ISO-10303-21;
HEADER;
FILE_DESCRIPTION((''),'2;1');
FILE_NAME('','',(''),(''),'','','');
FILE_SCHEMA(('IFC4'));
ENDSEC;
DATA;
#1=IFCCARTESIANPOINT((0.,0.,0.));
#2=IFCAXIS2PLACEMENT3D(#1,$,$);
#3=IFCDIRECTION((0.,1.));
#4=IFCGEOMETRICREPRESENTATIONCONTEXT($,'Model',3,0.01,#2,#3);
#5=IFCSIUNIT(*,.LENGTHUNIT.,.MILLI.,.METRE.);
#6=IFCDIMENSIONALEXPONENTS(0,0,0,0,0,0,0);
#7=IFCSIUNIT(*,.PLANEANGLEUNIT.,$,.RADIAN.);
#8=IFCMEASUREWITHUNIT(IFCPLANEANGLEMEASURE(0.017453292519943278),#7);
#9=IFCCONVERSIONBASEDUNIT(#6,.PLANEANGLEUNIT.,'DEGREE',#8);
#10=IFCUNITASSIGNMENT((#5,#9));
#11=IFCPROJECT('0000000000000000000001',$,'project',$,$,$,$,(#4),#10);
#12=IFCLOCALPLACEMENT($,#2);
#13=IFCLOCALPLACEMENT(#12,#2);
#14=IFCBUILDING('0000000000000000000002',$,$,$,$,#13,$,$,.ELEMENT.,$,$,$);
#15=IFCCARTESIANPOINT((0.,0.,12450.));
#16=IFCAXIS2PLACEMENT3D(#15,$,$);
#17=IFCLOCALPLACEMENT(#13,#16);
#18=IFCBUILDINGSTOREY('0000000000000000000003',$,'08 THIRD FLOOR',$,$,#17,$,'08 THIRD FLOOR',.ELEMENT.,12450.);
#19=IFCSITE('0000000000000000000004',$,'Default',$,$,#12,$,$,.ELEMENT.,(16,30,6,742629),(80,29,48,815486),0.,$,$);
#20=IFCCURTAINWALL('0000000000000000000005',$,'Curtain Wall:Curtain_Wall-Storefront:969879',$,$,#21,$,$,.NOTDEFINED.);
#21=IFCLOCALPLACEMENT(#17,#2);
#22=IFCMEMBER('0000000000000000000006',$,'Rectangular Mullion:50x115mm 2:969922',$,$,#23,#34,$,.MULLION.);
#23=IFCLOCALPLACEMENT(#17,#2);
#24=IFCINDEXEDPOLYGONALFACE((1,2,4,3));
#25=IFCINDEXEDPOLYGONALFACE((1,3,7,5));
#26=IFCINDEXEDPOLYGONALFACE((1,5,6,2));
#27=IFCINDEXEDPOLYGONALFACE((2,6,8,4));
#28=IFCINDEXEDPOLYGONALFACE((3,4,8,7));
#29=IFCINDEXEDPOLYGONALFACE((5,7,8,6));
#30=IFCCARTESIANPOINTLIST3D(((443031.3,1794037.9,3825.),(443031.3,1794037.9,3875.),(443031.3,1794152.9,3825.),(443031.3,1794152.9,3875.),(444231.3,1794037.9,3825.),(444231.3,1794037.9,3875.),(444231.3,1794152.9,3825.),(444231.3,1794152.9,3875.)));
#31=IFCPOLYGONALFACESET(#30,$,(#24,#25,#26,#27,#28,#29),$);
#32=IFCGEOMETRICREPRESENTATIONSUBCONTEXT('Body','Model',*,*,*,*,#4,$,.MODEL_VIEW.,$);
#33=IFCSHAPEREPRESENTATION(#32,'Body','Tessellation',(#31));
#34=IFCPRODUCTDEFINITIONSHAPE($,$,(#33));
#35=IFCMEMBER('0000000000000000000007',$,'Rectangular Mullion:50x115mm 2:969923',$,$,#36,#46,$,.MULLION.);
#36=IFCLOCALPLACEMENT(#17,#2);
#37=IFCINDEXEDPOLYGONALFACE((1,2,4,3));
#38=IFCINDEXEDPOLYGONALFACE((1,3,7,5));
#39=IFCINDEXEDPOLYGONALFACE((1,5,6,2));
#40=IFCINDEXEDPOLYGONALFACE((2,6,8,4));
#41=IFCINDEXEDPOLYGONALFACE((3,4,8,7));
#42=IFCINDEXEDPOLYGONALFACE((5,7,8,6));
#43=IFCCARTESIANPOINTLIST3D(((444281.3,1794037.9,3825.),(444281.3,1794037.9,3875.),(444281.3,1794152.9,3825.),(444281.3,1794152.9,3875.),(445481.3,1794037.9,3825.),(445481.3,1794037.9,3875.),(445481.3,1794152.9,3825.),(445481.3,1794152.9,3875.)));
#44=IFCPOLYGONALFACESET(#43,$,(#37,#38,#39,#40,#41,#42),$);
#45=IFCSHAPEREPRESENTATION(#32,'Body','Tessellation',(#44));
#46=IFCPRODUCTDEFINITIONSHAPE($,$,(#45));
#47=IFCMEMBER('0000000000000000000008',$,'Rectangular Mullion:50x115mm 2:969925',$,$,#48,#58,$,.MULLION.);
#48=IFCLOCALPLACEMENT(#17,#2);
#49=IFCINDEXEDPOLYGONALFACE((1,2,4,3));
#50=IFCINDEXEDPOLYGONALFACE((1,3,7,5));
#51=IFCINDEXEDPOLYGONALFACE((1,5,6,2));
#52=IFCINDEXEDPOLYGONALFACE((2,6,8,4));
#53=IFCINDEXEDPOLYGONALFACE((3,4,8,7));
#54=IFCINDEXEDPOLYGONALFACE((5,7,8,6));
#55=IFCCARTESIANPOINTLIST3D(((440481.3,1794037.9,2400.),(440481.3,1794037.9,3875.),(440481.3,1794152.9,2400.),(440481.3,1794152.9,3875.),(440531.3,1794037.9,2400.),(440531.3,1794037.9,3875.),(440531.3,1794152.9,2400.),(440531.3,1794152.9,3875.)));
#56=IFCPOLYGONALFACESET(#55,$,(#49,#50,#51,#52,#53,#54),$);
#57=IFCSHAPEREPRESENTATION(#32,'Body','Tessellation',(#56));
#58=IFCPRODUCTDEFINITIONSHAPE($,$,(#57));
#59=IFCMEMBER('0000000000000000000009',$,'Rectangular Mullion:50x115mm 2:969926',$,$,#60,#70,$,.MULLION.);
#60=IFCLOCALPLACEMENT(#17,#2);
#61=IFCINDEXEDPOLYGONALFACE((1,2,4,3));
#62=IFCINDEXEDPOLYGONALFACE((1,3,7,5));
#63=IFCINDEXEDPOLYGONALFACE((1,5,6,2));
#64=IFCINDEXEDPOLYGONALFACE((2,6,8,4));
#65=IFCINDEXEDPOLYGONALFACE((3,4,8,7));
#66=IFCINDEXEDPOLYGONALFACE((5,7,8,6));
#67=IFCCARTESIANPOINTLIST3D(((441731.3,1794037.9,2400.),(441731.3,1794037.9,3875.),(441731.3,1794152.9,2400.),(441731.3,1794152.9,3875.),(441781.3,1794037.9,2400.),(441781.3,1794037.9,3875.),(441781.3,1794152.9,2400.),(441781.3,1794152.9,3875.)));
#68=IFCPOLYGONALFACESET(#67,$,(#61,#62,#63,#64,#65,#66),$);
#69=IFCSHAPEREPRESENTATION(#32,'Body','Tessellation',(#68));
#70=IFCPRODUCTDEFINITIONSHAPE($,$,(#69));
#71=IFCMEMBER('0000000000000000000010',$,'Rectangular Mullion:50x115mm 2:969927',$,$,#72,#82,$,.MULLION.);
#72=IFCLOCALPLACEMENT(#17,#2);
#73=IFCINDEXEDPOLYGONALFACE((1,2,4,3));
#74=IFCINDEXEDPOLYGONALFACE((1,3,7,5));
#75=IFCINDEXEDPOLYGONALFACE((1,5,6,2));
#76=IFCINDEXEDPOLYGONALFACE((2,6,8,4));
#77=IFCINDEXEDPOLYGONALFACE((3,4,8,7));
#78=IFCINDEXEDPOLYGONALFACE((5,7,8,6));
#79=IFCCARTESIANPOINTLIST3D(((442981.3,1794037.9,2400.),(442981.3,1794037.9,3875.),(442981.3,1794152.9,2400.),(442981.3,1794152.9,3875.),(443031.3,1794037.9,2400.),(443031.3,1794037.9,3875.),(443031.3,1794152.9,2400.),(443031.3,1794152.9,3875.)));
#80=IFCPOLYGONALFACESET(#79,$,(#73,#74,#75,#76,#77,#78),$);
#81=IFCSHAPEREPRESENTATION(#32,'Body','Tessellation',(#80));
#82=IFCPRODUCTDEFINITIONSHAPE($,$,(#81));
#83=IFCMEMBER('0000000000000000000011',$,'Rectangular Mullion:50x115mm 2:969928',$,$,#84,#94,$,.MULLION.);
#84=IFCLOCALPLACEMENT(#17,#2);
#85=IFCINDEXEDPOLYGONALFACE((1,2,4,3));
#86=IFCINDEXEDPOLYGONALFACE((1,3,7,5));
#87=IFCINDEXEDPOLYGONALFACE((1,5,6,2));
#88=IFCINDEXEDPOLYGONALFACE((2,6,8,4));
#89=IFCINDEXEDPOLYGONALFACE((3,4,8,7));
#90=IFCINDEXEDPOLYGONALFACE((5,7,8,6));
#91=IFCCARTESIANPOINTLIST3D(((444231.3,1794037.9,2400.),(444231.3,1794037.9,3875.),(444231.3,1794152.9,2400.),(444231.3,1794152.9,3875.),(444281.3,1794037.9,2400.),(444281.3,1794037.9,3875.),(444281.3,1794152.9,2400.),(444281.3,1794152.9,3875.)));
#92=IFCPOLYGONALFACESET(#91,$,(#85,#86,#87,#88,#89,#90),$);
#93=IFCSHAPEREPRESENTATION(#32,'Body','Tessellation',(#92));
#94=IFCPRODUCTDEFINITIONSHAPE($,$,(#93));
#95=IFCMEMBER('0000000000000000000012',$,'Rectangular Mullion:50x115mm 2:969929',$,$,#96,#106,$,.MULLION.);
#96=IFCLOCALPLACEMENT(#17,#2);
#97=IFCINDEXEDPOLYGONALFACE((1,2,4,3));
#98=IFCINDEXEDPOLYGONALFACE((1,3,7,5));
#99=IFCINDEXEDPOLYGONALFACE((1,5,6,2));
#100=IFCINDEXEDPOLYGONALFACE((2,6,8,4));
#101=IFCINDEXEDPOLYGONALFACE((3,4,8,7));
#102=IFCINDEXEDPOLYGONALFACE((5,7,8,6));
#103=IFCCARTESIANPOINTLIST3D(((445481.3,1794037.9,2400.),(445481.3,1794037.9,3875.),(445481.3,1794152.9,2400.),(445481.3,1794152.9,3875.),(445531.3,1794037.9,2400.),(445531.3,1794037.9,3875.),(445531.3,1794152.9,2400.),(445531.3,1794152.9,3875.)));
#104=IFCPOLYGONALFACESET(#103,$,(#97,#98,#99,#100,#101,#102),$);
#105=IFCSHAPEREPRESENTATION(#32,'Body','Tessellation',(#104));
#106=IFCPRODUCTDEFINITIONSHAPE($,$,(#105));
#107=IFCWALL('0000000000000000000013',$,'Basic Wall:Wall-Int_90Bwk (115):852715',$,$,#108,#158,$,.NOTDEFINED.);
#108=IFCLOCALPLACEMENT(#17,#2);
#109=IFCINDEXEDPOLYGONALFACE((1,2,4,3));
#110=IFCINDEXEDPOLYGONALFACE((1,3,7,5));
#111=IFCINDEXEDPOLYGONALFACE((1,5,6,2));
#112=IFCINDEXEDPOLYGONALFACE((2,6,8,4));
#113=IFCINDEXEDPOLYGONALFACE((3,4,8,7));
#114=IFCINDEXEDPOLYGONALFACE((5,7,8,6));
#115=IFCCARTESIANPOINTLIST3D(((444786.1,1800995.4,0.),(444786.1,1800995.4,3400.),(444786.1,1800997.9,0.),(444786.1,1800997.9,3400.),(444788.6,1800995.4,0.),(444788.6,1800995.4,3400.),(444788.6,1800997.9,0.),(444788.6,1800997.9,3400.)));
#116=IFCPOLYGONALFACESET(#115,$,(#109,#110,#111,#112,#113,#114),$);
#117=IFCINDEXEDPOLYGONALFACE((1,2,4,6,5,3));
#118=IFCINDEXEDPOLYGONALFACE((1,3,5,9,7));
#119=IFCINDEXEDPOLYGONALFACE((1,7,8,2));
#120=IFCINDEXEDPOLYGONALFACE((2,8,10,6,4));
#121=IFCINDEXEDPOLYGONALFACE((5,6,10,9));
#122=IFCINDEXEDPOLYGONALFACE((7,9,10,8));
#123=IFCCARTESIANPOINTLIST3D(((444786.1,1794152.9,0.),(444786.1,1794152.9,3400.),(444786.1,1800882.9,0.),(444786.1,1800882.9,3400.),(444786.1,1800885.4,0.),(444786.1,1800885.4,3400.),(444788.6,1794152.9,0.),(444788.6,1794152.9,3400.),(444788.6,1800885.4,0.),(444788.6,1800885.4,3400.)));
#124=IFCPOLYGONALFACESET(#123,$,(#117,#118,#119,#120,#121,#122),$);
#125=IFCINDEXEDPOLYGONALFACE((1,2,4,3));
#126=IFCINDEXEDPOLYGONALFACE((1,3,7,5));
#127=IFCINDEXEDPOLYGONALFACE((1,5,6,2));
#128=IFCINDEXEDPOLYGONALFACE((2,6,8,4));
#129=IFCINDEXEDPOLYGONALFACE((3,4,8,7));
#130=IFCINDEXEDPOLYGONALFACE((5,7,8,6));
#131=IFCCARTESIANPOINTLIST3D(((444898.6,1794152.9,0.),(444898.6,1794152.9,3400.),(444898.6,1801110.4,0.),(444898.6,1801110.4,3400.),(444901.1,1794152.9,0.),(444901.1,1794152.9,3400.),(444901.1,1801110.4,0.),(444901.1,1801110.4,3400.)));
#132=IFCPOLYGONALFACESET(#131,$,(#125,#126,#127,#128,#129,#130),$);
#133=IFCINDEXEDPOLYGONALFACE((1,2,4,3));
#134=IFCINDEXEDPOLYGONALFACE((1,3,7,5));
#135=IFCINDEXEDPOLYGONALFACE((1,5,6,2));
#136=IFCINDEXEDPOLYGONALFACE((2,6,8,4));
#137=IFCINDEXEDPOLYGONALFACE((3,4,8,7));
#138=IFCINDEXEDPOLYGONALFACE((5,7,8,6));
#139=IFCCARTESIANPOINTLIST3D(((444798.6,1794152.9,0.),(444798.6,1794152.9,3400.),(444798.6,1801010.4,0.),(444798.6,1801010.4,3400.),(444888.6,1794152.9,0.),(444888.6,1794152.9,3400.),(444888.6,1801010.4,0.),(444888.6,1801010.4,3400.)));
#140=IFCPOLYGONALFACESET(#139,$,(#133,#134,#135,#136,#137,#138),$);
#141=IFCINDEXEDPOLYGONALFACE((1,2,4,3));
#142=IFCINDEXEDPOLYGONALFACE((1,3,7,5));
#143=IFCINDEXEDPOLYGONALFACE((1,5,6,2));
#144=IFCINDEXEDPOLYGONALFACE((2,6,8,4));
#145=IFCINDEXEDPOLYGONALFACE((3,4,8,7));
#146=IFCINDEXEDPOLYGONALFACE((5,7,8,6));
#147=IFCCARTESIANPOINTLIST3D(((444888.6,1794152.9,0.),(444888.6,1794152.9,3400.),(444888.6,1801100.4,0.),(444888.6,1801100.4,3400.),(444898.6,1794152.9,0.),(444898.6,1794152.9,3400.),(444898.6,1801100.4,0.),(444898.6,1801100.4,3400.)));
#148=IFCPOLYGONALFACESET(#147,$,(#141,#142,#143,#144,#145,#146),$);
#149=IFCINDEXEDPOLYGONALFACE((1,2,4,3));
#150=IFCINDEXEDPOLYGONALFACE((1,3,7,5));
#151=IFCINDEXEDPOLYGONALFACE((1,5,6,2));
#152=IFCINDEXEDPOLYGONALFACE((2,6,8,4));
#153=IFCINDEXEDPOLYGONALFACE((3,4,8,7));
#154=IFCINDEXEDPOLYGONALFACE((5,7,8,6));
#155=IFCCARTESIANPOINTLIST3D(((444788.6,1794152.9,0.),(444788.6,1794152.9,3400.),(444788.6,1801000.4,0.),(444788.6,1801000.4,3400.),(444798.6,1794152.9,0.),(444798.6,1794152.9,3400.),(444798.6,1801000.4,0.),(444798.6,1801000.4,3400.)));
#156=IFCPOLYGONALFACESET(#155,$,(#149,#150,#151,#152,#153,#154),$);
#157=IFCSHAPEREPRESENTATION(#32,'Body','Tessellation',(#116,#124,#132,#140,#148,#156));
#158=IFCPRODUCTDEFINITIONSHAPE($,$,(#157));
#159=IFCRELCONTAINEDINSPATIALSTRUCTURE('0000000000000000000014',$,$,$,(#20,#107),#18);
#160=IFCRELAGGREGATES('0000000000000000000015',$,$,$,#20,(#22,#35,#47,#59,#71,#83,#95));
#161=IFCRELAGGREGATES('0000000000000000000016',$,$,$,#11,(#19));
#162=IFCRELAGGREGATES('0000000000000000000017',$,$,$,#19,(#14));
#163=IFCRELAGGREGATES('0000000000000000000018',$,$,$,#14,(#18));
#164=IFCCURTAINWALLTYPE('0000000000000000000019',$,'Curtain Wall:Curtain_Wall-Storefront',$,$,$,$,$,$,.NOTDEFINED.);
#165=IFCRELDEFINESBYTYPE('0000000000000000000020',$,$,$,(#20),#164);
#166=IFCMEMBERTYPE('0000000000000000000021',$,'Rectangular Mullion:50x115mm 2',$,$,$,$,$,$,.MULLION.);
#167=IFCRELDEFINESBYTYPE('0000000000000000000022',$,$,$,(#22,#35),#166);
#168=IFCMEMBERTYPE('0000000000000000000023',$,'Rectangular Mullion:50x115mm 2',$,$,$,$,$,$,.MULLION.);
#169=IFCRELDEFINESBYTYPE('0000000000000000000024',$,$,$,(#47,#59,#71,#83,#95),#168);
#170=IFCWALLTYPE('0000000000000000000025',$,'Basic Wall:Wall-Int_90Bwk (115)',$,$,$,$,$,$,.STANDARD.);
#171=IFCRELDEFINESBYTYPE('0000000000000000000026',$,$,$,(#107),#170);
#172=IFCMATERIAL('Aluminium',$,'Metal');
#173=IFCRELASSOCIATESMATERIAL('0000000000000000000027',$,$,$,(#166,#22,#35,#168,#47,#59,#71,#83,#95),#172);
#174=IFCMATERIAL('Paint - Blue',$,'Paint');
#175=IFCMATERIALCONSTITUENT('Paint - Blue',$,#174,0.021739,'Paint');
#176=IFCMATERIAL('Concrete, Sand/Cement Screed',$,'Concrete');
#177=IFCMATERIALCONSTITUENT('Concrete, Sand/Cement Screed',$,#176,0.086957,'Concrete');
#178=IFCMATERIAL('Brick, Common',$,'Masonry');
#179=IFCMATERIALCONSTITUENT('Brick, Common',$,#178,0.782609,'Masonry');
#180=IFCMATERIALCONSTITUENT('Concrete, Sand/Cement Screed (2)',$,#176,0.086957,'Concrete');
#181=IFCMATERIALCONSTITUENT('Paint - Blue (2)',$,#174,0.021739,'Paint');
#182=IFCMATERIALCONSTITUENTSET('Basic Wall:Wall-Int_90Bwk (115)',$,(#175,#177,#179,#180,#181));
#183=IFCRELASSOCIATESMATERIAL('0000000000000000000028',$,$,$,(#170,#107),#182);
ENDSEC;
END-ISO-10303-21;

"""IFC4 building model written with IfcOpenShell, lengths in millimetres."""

from ifc_helpers import new_model, entity, si_unit, converted_unit, direction, frame, origin, place, context, subcontext, project, spatial, indexed_curve, outline, extrude, source, transform, mapped, material, constituent, constituent_set, type_object, type_shapes, element, aggregate, save


model = new_model("IFC4")

# Units and contexts
model_context = context("Model", 3, precision=0.01, world=origin(), true_north=direction((0.0, 1.0)))
body_context = subcontext(model_context, "Body", "Model", "MODEL_VIEW")
ifc_project = project(units=[si_unit("LENGTHUNIT", "METRE", prefix="MILLI"), converted_unit("PLANEANGLEUNIT", "DEGREE", entity("IfcPlaneAngleMeasure", 0.017453292519943278), si_unit("PLANEANGLEUNIT", "RADIAN"), dimensions=[0, 0, 0, 0, 0, 0, 0])], contexts=[model_context])

# Site, building, storey
site_placement = place(None, origin())
site = spatial("IfcSite", under=ifc_project, at=site_placement, Name="Default", CompositionType="ELEMENT", RefLatitude=(16, 30, 6, 742629), RefLongitude=(80, 29, 48, 815486), RefElevation=0.0)
building_placement = place(site_placement, origin())
building = spatial("IfcBuilding", under=site, at=building_placement, CompositionType="ELEMENT")
storey_placement = place(building_placement, frame((0.0, 0.0, 12450.0)))
storey = spatial("IfcBuildingStorey", under=building, at=storey_placement, Name="08 THIRD FLOOR", LongName="08 THIRD FLOOR", CompositionType="ELEMENT", Elevation=12450.0)

# Curtain wall, members
curtain_wall_type = type_object("IfcCurtainWallType", Name="Curtain Wall:Curtain_Wall-Storefront", PredefinedType="NOTDEFINED")
curtain_wall_placement = place(storey_placement, frame((0.0, 0.0, -12450.0)))
curtain_wall = element("IfcCurtainWall", 1, at=curtain_wall_placement, inside=storey, type_object=curtain_wall_type, Name="Curtain Wall:Curtain_Wall-Storefront:969879", PredefinedType="NOTDEFINED")
ifc_material_1 = material(Name="Aluminium", Category="Metal")
member_type_1 = type_object("IfcMemberType", Name="Rectangular Mullion:50x115mm 2", PredefinedType="MULLION", material=ifc_material_1)
shared_shape_1 = source(origin(), body_context, "Body", "SweptSolid", [
    extrude(outline(indexed_curve([(-25.0, -57.5), (25.0, -57.5), (25.0, 57.5), (-25.0, 57.5), (-25.0, -57.5)], self_intersect=False)), frame((-25.0, 0.0, -1200.0), z_axis=(0.0, 0.0, 1.0), x_axis=(-1.0, 0.0, 0.0)), (0.0, 0.0, 1.0), 1200.0),
])
type_shapes(member_type_1, [shared_shape_1])
member_1_placement = place(curtain_wall_placement, frame((444231.3, 1794095.4, 16325.0), z_axis=(1.0, 0.0, 0.0), x_axis=(0.0, 0.0, 1.0)))
member_1 = element("IfcMember", 2, at=member_1_placement, type_object=member_type_1, material=ifc_material_1, Name="Rectangular Mullion:50x115mm 2:969922", PredefinedType="MULLION", context=body_context, shape_type="MappedRepresentation", body=[
    mapped(shared_shape_1, transform((0.0, 0.0, 0.0), scale=1.0)),
])
member_2_placement = place(curtain_wall_placement, frame((445481.3, 1794095.4, 16325.0), z_axis=(1.0, 0.0, 0.0), x_axis=(0.0, 0.0, 1.0)))
member_2 = element("IfcMember", 3, at=member_2_placement, type_object=member_type_1, material=ifc_material_1, Name="Rectangular Mullion:50x115mm 2:969923", PredefinedType="MULLION", context=body_context, shape_type="MappedRepresentation", body=[
    mapped(shared_shape_1, transform((0.0, 0.0, 0.0), scale=1.0)),
])
member_type_2 = type_object("IfcMemberType", Name="Rectangular Mullion:50x115mm 2", PredefinedType="MULLION", material=ifc_material_1)
shared_shape_2 = source(origin(), body_context, "Body", "SweptSolid", [
    extrude(outline(indexed_curve([(-25.0, -57.5), (25.0, -57.5), (25.0, 57.5), (-25.0, 57.5), (-25.0, -57.5)], self_intersect=False)), frame((0.0, 0.0, -1475.0), z_axis=(0.0, 0.0, 1.0), x_axis=(-1.0, 0.0, 0.0)), (0.0, 0.0, 1.0), 1475.0),
])
type_shapes(member_type_2, [shared_shape_2])
member_3_placement = place(curtain_wall_placement, frame((440506.3, 1794095.4, 14850.0), z_axis=(0.0, 0.0, -1.0), x_axis=(1.0, 0.0, 0.0)))
member_3 = element("IfcMember", 4, at=member_3_placement, type_object=member_type_2, material=ifc_material_1, Name="Rectangular Mullion:50x115mm 2:969925", PredefinedType="MULLION", context=body_context, shape_type="MappedRepresentation", body=[
    mapped(shared_shape_2, transform((0.0, 0.0, 0.0), scale=1.0)),
])
member_4_placement = place(curtain_wall_placement, frame((441756.3, 1794095.4, 14850.0), z_axis=(0.0, 0.0, -1.0), x_axis=(1.0, 0.0, 0.0)))
member_4 = element("IfcMember", 5, at=member_4_placement, type_object=member_type_2, material=ifc_material_1, Name="Rectangular Mullion:50x115mm 2:969926", PredefinedType="MULLION", context=body_context, shape_type="MappedRepresentation", body=[
    mapped(shared_shape_2, transform((0.0, 0.0, 0.0), scale=1.0)),
])
member_5_placement = place(curtain_wall_placement, frame((443006.3, 1794095.4, 14850.0), z_axis=(0.0, 0.0, -1.0), x_axis=(1.0, 0.0, 0.0)))
member_5 = element("IfcMember", 6, at=member_5_placement, type_object=member_type_2, material=ifc_material_1, Name="Rectangular Mullion:50x115mm 2:969927", PredefinedType="MULLION", context=body_context, shape_type="MappedRepresentation", body=[
    mapped(shared_shape_2, transform((0.0, 0.0, 0.0), scale=1.0)),
])
member_6_placement = place(curtain_wall_placement, frame((444256.3, 1794095.4, 14850.0), z_axis=(0.0, 0.0, -1.0), x_axis=(1.0, 0.0, 0.0)))
member_6 = element("IfcMember", 7, at=member_6_placement, type_object=member_type_2, material=ifc_material_1, Name="Rectangular Mullion:50x115mm 2:969928", PredefinedType="MULLION", context=body_context, shape_type="MappedRepresentation", body=[
    mapped(shared_shape_2, transform((0.0, 0.0, 0.0), scale=1.0)),
])
member_7_placement = place(curtain_wall_placement, frame((445506.3, 1794095.4, 14850.0), z_axis=(0.0, 0.0, -1.0), x_axis=(1.0, 0.0, 0.0)))
member_7 = element("IfcMember", 8, at=member_7_placement, type_object=member_type_2, material=ifc_material_1, Name="Rectangular Mullion:50x115mm 2:969929", PredefinedType="MULLION", context=body_context, shape_type="MappedRepresentation", body=[
    mapped(shared_shape_2, transform((0.0, 0.0, 0.0), scale=1.0)),
])
aggregate(curtain_wall, [member_1, member_2, member_3, member_4, member_5, member_6, member_7])

# Shared definitions
ifc_material_2 = material(Name="Paint - Blue", Category="Paint")
ifc_constituent_1 = constituent(ifc_material_2, Name="Paint - Blue", Category="Paint", fraction=0.021739)
ifc_material_3 = material(Name="Concrete, Sand/Cement Screed", Category="Concrete")
ifc_constituent_2 = constituent(ifc_material_3, Name="Concrete, Sand/Cement Screed", Category="Concrete", fraction=0.086957)
ifc_material_4 = material(Name="Brick, Common", Category="Masonry")
ifc_constituent_3 = constituent(ifc_material_4, Name="Brick, Common", Category="Masonry", fraction=0.782609)
ifc_constituent_4 = constituent(ifc_material_3, Name="Concrete, Sand/Cement Screed (2)", Category="Concrete", fraction=0.086957)
ifc_constituent_5 = constituent(ifc_material_2, Name="Paint - Blue (2)", Category="Paint", fraction=0.021739)
ifc_constituent_set_1 = constituent_set(constituents=[ifc_constituent_1, ifc_constituent_2, ifc_constituent_3, ifc_constituent_4, ifc_constituent_5], Name="Basic Wall:Wall-Int_90Bwk (115)")
wall_type_1 = type_object("IfcWallType", Name="Basic Wall:Wall-Int_90Bwk (115)", PredefinedType="STANDARD", material=ifc_constituent_set_1)

# Wall
wall_1_placement = place(storey_placement, frame((444843.6, 1794152.9, 0.0), z_axis=(0.0, 0.0, 1.0), x_axis=(0.0, 1.0, 0.0)))
element("IfcWall", 9, at=wall_1_placement, inside=storey, type_object=wall_type_1, material=ifc_constituent_set_1, Name="Basic Wall:Wall-Int_90Bwk (115):852715", PredefinedType="NOTDEFINED", context=body_context, shape_type="SweptSolid", body=[
    extrude(outline(indexed_curve([(-1.3, -1.2), (1.3, -1.2), (1.3, 1.3), (-1.3, 1.3), (-1.3, -1.2)], self_intersect=False)), frame((6843.8, 56.3, 0.0), z_axis=(0.0, 0.0, 1.0), x_axis=(-1.0, 0.0, 0.0)), (0.0, 0.0, 1.0), 3400.0),
    extrude(outline(indexed_curve([(-4039.0, -1.5), (2693.5, -1.5), (2693.5, 1.0), (2691.0, 1.0), (-4039.0, 1.0), (-4039.0, -1.5)], self_intersect=False)), frame((4039.0, 56.5, 0.0)), (0.0, 0.0, 1.0), 3400.0),
    extrude(outline(indexed_curve([(-1.3, -3478.8), (1.2, -3478.8), (1.2, 3478.8), (-1.3, 3478.8), (-1.3, -3478.8)], self_intersect=False)), frame((3478.8, -56.2, 0.0), z_axis=(0.0, 0.0, 1.0), x_axis=(0.0, 1.0, 0.0)), (0.0, 0.0, 1.0), 3400.0),
    extrude(outline(indexed_curve([(-3428.8, -45.0), (3428.8, -45.0), (3428.8, 45.0), (-3428.8, 45.0), (-3428.8, -45.0)], self_intersect=False)), frame((3428.8, 0.0, 0.0)), (0.0, 0.0, 1.0), 3400.0),
    extrude(outline(indexed_curve([(-3473.8, -5.0), (3473.8, -5.0), (3473.8, 5.0), (-3473.8, 5.0), (-3473.8, -5.0)], self_intersect=False)), frame((3473.8, -50.0, 0.0)), (0.0, 0.0, 1.0), 3400.0),
    extrude(outline(indexed_curve([(-3423.8, -5.0), (3423.8, -5.0), (3423.8, 5.0), (-3423.8, 5.0), (-3423.8, -5.0)], self_intersect=False)), frame((3423.8, 50.0, 0.0)), (0.0, 0.0, 1.0), 3400.0),
])

save(model, "model.ifc")
